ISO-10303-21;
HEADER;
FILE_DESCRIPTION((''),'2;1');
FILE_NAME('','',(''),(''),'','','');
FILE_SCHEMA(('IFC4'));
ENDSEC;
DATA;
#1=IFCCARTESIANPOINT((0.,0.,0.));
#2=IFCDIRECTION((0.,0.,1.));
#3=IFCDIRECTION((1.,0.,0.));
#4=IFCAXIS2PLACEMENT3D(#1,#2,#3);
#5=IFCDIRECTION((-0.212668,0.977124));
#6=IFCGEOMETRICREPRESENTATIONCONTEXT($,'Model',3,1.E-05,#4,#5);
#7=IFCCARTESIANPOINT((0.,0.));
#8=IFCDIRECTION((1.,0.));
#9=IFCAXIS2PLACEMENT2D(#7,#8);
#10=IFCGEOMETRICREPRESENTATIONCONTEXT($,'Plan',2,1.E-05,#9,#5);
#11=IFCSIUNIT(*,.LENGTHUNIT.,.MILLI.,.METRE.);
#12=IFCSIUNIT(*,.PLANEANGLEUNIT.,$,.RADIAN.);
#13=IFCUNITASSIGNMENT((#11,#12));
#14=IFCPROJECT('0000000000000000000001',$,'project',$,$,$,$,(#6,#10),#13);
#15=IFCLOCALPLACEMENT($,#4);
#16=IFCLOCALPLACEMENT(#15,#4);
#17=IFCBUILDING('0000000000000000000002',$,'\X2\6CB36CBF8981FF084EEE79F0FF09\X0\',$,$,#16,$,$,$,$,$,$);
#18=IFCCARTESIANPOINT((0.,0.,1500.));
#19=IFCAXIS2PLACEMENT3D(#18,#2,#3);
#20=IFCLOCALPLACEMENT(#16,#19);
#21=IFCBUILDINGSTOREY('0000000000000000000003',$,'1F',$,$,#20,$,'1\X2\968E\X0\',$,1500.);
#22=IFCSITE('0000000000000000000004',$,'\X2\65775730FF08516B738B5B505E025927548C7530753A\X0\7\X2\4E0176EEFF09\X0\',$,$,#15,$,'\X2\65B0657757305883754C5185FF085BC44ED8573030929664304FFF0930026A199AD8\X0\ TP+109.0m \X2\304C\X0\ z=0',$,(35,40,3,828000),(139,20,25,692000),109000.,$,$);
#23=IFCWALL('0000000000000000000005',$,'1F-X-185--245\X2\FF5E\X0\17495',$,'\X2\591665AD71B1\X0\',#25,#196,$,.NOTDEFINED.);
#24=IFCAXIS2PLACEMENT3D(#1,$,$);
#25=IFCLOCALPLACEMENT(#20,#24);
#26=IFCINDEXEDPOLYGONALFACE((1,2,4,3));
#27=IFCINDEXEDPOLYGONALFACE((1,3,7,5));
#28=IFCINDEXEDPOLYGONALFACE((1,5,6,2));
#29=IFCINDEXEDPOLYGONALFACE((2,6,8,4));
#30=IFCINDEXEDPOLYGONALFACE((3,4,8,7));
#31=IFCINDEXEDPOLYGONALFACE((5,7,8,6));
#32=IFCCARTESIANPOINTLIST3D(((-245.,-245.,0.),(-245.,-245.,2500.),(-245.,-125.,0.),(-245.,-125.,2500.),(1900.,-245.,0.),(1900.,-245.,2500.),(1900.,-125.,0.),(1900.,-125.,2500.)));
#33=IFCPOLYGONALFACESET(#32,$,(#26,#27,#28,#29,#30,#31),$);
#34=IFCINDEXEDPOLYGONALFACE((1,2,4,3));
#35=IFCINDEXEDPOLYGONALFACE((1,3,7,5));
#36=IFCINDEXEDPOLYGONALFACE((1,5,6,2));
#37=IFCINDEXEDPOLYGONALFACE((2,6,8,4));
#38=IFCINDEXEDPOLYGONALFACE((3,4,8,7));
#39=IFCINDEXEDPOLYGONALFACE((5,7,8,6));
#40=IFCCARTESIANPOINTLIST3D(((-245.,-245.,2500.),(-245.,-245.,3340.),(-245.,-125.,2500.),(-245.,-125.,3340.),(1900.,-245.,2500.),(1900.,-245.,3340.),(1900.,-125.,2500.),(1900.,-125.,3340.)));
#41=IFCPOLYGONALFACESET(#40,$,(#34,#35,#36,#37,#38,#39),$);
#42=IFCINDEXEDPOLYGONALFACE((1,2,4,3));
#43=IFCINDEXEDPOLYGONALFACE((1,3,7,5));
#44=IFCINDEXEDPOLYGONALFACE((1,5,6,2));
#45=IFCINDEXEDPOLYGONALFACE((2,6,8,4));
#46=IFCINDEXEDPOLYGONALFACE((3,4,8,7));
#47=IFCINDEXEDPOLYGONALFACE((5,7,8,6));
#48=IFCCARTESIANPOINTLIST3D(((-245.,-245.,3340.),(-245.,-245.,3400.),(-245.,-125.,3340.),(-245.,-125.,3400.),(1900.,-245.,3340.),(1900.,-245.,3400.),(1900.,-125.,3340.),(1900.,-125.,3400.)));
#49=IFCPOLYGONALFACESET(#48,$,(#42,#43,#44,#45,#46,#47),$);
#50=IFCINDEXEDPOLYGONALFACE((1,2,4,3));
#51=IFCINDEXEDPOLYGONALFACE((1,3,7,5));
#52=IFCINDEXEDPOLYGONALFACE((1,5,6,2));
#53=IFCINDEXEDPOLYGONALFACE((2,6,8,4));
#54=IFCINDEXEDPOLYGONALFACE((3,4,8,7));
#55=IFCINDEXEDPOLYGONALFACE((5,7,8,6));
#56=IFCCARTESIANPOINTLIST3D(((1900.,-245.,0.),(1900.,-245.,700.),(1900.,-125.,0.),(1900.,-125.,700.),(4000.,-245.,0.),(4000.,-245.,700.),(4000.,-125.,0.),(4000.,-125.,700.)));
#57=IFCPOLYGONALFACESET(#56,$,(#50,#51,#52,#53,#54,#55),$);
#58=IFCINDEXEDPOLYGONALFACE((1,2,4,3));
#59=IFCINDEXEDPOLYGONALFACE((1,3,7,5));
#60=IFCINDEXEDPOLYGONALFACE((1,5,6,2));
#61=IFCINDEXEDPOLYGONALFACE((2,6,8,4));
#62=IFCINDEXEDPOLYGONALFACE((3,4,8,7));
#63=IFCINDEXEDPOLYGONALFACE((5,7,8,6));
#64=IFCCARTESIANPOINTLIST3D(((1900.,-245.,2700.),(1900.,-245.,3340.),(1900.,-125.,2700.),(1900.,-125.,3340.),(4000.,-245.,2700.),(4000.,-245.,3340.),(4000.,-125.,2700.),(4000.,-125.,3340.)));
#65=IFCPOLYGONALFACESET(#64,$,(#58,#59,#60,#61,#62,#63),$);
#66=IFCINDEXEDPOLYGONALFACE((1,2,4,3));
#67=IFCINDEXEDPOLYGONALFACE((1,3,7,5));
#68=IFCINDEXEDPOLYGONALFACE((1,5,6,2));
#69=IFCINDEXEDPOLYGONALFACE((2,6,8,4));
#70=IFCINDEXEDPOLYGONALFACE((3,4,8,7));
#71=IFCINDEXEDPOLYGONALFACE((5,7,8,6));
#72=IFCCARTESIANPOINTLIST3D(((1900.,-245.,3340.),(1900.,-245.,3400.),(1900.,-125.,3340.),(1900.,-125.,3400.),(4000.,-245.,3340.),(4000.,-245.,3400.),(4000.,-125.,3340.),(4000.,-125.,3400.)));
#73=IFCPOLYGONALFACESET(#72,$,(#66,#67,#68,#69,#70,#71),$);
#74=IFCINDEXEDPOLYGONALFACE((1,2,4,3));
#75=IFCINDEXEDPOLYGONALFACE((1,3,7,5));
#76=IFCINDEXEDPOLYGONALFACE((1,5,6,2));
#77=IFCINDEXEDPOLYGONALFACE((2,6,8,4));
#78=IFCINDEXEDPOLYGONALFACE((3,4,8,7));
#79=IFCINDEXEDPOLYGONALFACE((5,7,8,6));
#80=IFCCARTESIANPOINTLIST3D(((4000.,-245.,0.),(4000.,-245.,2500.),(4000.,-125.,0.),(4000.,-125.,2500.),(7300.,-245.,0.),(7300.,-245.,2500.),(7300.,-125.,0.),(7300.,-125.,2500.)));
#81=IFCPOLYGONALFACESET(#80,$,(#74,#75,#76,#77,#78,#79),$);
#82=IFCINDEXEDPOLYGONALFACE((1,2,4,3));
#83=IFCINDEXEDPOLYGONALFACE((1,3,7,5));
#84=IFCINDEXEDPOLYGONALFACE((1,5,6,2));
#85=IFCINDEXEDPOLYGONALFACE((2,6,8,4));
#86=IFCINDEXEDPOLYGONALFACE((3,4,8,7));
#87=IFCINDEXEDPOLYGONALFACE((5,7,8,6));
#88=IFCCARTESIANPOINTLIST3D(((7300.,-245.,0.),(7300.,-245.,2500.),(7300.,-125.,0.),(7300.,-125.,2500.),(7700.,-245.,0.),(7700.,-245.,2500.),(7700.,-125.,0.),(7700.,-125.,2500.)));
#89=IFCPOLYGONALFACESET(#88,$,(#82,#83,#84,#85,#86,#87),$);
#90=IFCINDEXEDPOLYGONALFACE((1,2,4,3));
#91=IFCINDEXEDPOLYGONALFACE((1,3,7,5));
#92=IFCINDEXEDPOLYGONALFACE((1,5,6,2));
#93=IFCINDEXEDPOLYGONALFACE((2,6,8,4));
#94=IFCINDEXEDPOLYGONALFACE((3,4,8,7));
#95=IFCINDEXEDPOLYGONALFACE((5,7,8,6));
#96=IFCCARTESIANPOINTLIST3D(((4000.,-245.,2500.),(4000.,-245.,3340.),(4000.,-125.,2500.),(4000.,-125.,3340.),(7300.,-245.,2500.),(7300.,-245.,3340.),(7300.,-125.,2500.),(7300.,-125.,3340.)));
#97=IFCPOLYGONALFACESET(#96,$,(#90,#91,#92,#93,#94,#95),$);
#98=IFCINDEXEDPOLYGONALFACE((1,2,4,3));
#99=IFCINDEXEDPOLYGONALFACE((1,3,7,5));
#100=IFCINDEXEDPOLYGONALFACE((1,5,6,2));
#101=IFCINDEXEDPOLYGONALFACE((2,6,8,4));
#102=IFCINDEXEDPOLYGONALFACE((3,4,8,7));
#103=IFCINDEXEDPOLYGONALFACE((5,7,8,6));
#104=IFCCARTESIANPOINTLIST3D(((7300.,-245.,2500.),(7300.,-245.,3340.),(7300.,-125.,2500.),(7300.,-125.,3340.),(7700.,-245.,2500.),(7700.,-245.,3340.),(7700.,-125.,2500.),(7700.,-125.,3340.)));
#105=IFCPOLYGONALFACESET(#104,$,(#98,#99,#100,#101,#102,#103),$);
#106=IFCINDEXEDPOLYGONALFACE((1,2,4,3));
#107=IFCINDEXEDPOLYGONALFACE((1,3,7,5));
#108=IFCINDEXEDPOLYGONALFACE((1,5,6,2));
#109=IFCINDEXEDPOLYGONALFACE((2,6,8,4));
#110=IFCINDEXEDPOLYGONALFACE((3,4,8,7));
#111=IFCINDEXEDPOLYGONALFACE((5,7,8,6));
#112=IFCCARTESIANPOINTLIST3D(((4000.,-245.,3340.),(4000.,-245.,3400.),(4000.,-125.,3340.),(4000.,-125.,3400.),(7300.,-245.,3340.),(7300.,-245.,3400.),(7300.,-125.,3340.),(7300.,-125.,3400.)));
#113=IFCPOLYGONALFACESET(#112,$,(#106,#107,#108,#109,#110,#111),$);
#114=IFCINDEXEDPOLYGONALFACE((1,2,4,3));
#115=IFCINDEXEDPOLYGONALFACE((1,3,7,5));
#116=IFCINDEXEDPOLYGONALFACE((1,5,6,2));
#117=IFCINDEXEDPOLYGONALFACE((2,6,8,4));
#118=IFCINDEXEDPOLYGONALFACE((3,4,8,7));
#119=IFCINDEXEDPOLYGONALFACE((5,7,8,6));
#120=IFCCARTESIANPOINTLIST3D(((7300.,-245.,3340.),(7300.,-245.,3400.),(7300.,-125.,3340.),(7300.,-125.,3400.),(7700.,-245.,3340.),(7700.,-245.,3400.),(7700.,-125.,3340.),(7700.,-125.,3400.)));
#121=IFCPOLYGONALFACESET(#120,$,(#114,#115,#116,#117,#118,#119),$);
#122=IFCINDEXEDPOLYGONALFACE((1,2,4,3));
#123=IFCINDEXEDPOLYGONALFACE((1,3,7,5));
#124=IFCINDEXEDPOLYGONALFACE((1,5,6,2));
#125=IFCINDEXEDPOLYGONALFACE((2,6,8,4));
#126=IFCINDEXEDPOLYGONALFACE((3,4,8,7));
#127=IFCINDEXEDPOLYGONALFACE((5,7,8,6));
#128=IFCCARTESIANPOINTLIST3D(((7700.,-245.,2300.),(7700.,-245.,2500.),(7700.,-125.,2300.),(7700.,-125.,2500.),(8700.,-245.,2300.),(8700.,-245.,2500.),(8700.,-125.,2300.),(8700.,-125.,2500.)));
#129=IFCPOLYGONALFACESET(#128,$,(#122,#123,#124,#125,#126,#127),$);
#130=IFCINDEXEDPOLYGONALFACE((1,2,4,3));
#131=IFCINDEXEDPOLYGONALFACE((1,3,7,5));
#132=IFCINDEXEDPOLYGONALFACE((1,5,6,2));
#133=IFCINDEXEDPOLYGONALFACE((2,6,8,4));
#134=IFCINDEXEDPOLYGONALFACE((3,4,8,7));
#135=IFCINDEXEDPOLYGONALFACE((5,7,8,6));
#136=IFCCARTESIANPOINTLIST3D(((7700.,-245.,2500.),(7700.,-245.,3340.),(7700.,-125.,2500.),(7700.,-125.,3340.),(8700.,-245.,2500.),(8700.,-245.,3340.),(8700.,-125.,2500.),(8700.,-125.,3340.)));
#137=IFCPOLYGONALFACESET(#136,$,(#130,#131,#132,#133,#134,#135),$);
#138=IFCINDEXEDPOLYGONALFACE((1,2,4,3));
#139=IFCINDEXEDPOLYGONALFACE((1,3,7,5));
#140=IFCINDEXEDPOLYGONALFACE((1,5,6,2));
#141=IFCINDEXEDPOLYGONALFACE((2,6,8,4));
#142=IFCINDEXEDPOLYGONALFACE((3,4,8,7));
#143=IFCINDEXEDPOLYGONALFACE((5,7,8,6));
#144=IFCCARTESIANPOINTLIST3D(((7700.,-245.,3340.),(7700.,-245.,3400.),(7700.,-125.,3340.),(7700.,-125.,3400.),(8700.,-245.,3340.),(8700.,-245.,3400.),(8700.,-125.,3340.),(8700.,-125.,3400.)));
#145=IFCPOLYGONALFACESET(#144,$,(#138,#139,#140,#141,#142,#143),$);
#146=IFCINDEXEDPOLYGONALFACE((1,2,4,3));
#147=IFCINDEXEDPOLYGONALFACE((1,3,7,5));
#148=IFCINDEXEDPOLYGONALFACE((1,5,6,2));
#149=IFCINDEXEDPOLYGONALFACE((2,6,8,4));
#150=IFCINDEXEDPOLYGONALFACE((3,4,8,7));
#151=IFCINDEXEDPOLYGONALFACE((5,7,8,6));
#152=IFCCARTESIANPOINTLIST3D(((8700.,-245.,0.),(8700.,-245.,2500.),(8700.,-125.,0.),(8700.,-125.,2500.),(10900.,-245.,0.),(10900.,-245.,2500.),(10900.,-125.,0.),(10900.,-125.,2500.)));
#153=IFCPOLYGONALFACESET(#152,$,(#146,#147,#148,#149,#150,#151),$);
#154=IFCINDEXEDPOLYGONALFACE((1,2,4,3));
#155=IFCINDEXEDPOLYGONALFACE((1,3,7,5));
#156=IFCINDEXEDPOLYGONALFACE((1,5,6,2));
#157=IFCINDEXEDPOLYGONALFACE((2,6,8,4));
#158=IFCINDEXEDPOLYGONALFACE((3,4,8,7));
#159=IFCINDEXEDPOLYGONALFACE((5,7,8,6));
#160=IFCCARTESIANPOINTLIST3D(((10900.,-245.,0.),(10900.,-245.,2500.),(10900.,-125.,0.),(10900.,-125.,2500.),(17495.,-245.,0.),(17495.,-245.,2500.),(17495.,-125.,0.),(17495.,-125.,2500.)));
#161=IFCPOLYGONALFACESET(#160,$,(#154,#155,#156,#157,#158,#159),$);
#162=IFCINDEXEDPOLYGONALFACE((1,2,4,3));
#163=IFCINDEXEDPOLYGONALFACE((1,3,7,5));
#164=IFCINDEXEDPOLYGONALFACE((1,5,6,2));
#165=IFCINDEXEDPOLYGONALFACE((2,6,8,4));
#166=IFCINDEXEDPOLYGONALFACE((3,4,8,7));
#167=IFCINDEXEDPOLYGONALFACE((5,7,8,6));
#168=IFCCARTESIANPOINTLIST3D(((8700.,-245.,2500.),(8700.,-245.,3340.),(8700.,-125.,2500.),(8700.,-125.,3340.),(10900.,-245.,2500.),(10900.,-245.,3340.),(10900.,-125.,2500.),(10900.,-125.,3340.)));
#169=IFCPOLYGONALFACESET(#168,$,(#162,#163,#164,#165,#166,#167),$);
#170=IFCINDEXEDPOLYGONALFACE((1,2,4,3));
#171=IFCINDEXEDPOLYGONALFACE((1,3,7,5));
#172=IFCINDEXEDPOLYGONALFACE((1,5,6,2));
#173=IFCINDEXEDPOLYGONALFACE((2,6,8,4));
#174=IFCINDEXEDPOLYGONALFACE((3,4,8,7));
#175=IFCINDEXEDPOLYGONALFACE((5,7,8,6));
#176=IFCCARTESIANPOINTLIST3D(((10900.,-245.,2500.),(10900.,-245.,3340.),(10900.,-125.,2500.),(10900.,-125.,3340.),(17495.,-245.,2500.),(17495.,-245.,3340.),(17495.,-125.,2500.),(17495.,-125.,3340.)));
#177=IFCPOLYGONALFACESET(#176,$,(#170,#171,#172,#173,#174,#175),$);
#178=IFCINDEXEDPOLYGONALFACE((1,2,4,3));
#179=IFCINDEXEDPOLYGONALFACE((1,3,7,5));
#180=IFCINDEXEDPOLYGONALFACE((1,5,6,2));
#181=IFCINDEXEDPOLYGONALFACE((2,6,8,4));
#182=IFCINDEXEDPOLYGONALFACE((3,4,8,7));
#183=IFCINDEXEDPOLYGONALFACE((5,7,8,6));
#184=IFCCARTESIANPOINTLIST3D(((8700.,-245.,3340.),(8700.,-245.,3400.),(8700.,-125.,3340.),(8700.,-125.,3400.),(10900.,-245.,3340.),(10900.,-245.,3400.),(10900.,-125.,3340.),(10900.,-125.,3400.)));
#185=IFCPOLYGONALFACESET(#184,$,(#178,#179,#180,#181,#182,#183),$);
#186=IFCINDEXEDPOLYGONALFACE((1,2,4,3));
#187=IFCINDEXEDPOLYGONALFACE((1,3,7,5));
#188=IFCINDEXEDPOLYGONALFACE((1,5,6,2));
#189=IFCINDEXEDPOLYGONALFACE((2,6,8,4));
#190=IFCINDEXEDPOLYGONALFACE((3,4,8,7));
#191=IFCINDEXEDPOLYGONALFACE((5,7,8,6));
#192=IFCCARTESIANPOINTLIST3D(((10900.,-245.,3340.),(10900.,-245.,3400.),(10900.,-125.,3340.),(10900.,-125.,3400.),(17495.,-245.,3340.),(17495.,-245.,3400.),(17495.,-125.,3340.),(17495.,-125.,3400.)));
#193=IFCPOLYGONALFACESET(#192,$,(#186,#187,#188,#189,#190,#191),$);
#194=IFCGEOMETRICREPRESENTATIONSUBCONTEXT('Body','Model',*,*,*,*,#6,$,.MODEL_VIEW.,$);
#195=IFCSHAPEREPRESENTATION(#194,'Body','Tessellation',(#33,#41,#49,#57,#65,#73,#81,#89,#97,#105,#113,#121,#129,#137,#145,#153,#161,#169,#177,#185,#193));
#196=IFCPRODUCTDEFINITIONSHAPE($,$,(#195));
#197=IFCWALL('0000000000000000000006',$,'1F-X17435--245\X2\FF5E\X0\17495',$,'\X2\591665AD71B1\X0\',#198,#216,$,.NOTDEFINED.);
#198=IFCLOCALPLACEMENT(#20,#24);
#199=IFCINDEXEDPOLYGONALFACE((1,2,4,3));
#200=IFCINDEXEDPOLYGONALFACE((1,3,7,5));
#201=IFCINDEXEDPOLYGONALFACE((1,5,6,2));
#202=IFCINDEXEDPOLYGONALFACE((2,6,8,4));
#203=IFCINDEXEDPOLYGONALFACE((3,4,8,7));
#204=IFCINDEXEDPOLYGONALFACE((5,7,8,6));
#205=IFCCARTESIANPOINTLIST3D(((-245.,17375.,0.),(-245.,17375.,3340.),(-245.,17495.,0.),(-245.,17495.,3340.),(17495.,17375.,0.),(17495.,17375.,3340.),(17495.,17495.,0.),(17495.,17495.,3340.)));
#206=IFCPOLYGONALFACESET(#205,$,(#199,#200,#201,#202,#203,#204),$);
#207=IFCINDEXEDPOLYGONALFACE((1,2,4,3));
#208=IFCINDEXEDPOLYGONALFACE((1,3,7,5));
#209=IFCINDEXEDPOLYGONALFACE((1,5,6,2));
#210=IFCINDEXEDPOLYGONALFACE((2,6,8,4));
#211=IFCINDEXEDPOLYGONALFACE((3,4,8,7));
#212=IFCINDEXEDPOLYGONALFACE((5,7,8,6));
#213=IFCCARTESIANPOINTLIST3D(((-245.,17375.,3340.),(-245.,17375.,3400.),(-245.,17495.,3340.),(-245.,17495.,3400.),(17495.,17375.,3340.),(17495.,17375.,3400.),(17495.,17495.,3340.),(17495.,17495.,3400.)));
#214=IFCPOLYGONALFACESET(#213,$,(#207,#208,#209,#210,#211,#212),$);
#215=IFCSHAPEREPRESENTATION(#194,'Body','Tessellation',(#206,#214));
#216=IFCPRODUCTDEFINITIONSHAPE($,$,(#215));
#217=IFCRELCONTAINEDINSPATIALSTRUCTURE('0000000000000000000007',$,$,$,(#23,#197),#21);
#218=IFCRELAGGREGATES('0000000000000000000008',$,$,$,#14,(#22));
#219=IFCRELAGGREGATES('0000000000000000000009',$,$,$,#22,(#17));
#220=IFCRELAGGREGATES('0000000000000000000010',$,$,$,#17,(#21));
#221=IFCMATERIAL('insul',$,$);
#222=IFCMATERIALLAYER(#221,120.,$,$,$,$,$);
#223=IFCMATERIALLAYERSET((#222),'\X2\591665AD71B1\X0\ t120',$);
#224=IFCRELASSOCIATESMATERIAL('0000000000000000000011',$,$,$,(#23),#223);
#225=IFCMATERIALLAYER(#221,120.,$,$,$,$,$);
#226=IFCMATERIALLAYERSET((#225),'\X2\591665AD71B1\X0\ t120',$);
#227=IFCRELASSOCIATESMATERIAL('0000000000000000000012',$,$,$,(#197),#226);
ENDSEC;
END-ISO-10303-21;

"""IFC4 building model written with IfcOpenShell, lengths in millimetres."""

from ifc_helpers import new_model, si_unit, direction, frame, frame_2d, origin, origin_with_axes, origin_2d_with_axis, place, context, subcontext, project, spatial, rectangle, extrude, material, layer, layer_set, layer_usage, element, save


model = new_model("IFC4")

# Units and contexts
model_context = context("Model", 3, precision=1e-05, world=origin_with_axes(), true_north=direction((-0.212668, 0.977124)))
plan_context = context("Plan", 2, precision=1e-05, world=origin_2d_with_axis(), true_north=direction((-0.212668, 0.977124)))
body_context = subcontext(model_context, "Body", "Model", "MODEL_VIEW")
ifc_project = project(units=[si_unit("LENGTHUNIT", "METRE", prefix="MILLI"), si_unit("PLANEANGLEUNIT", "RADIAN")], contexts=[model_context, plan_context])

# Site, building, storey
site_placement = place(None, origin_with_axes())
site = spatial("IfcSite", under=ifc_project, at=site_placement, Name="敷地（八王子市大和田町7丁目）", LongName="新敷地境界内（寄付地を除く）。標高 TP+109.0m が z=0", RefLatitude=(35, 40, 3, 828000), RefLongitude=(139, 20, 25, 692000), RefElevation=109000.0)
building_placement = place(site_placement, origin_with_axes())
building = spatial("IfcBuilding", under=site, at=building_placement, Name="河沿要（仮称）")
storey_placement = place(building_placement, frame((0.0, 0.0, 1500.0), z_axis=(0.0, 0.0, 1.0), x_axis=(1.0, 0.0, 0.0)))
storey = spatial("IfcBuildingStorey", under=building, at=storey_placement, Name="1F", LongName="1階", Elevation=1500.0)

# Walls
ifc_material_1 = material(Name="insul")
ifc_layer_1 = layer(ifc_material_1, 120.0)
ifc_layer_set_1 = layer_set([ifc_layer_1], Name="外断熱 t120")
ifc_layer_usage_1 = layer_usage(ifc_layer_set_1, "AXIS2", "POSITIVE", 0.0)
wall_1_placement = place(storey_placement, origin_with_axes())
element("IfcWall", 1, at=wall_1_placement, inside=storey, material=ifc_layer_usage_1, Name="1F-X-185--245～17495", ObjectType="外断熱", PredefinedType="NOTDEFINED", context=body_context, shape_type="SweptSolid", body=[
    extrude(rectangle(XDim=2145.0, YDim=120.0, at=frame_2d((827.5, -185.0))), origin(), (0.0, 0.0, 1.0), 2500.0),
    extrude(rectangle(XDim=2145.0, YDim=120.0, at=frame_2d((827.5, -185.0))), frame((0.0, 0.0, 2500.0)), (0.0, 0.0, 1.0), 840.0),
    extrude(rectangle(XDim=2145.0, YDim=120.0, at=frame_2d((827.5, -185.0))), frame((0.0, 0.0, 3340.0)), (0.0, 0.0, 1.0), 60.0),
    extrude(rectangle(XDim=2100.0, YDim=120.0, at=frame_2d((2950.0, -185.0))), origin(), (0.0, 0.0, 1.0), 700.0),
    extrude(rectangle(XDim=2100.0, YDim=120.0, at=frame_2d((2950.0, -185.0))), frame((0.0, 0.0, 2700.0)), (0.0, 0.0, 1.0), 640.0),
    extrude(rectangle(XDim=2100.0, YDim=120.0, at=frame_2d((2950.0, -185.0))), frame((0.0, 0.0, 3340.0)), (0.0, 0.0, 1.0), 60.0),
    extrude(rectangle(XDim=3300.0, YDim=120.0, at=frame_2d((5650.0, -185.0))), origin(), (0.0, 0.0, 1.0), 2500.0),
    extrude(rectangle(XDim=400.0, YDim=120.0, at=frame_2d((7500.0, -185.0))), origin(), (0.0, 0.0, 1.0), 2500.0),
    extrude(rectangle(XDim=3300.0, YDim=120.0, at=frame_2d((5650.0, -185.0))), frame((0.0, 0.0, 2500.0)), (0.0, 0.0, 1.0), 840.0),
    extrude(rectangle(XDim=400.0, YDim=120.0, at=frame_2d((7500.0, -185.0))), frame((0.0, 0.0, 2500.0)), (0.0, 0.0, 1.0), 840.0),
    extrude(rectangle(XDim=3300.0, YDim=120.0, at=frame_2d((5650.0, -185.0))), frame((0.0, 0.0, 3340.0)), (0.0, 0.0, 1.0), 60.0),
    extrude(rectangle(XDim=400.0, YDim=120.0, at=frame_2d((7500.0, -185.0))), frame((0.0, 0.0, 3340.0)), (0.0, 0.0, 1.0), 60.0),
    extrude(rectangle(XDim=1000.0, YDim=120.0, at=frame_2d((8200.0, -185.0))), frame((0.0, 0.0, 2300.0)), (0.0, 0.0, 1.0), 200.0),
    extrude(rectangle(XDim=1000.0, YDim=120.0, at=frame_2d((8200.0, -185.0))), frame((0.0, 0.0, 2500.0)), (0.0, 0.0, 1.0), 840.0),
    extrude(rectangle(XDim=1000.0, YDim=120.0, at=frame_2d((8200.0, -185.0))), frame((0.0, 0.0, 3340.0)), (0.0, 0.0, 1.0), 60.0),
    extrude(rectangle(XDim=2200.0, YDim=120.0, at=frame_2d((9800.0, -185.0))), origin(), (0.0, 0.0, 1.0), 2500.0),
    extrude(rectangle(XDim=6595.0, YDim=120.0, at=frame_2d((14197.5, -185.0))), origin(), (0.0, 0.0, 1.0), 2500.0),
    extrude(rectangle(XDim=2200.0, YDim=120.0, at=frame_2d((9800.0, -185.0))), frame((0.0, 0.0, 2500.0)), (0.0, 0.0, 1.0), 840.0),
    extrude(rectangle(XDim=6595.0, YDim=120.0, at=frame_2d((14197.5, -185.0))), frame((0.0, 0.0, 2500.0)), (0.0, 0.0, 1.0), 840.0),
    extrude(rectangle(XDim=2200.0, YDim=120.0, at=frame_2d((9800.0, -185.0))), frame((0.0, 0.0, 3340.0)), (0.0, 0.0, 1.0), 60.0),
    extrude(rectangle(XDim=6595.0, YDim=120.0, at=frame_2d((14197.5, -185.0))), frame((0.0, 0.0, 3340.0)), (0.0, 0.0, 1.0), 60.0),
])
ifc_layer_2 = layer(ifc_material_1, 120.0)
ifc_layer_set_2 = layer_set([ifc_layer_2], Name="外断熱 t120")
ifc_layer_usage_2 = layer_usage(ifc_layer_set_2, "AXIS2", "POSITIVE", 0.0)
wall_2_placement = place(storey_placement, origin_with_axes())
element("IfcWall", 2, at=wall_2_placement, inside=storey, material=ifc_layer_usage_2, Name="1F-X17435--245～17495", ObjectType="外断熱", PredefinedType="NOTDEFINED", context=body_context, shape_type="SweptSolid", body=[
    extrude(rectangle(XDim=17740.0, YDim=120.0, at=frame_2d((8625.0, 17435.0))), origin(), (0.0, 0.0, 1.0), 3340.0),
    extrude(rectangle(XDim=17740.0, YDim=120.0, at=frame_2d((8625.0, 17435.0))), frame((0.0, 0.0, 3340.0)), (0.0, 0.0, 1.0), 60.0),
])

save(model, "model.ifc")
